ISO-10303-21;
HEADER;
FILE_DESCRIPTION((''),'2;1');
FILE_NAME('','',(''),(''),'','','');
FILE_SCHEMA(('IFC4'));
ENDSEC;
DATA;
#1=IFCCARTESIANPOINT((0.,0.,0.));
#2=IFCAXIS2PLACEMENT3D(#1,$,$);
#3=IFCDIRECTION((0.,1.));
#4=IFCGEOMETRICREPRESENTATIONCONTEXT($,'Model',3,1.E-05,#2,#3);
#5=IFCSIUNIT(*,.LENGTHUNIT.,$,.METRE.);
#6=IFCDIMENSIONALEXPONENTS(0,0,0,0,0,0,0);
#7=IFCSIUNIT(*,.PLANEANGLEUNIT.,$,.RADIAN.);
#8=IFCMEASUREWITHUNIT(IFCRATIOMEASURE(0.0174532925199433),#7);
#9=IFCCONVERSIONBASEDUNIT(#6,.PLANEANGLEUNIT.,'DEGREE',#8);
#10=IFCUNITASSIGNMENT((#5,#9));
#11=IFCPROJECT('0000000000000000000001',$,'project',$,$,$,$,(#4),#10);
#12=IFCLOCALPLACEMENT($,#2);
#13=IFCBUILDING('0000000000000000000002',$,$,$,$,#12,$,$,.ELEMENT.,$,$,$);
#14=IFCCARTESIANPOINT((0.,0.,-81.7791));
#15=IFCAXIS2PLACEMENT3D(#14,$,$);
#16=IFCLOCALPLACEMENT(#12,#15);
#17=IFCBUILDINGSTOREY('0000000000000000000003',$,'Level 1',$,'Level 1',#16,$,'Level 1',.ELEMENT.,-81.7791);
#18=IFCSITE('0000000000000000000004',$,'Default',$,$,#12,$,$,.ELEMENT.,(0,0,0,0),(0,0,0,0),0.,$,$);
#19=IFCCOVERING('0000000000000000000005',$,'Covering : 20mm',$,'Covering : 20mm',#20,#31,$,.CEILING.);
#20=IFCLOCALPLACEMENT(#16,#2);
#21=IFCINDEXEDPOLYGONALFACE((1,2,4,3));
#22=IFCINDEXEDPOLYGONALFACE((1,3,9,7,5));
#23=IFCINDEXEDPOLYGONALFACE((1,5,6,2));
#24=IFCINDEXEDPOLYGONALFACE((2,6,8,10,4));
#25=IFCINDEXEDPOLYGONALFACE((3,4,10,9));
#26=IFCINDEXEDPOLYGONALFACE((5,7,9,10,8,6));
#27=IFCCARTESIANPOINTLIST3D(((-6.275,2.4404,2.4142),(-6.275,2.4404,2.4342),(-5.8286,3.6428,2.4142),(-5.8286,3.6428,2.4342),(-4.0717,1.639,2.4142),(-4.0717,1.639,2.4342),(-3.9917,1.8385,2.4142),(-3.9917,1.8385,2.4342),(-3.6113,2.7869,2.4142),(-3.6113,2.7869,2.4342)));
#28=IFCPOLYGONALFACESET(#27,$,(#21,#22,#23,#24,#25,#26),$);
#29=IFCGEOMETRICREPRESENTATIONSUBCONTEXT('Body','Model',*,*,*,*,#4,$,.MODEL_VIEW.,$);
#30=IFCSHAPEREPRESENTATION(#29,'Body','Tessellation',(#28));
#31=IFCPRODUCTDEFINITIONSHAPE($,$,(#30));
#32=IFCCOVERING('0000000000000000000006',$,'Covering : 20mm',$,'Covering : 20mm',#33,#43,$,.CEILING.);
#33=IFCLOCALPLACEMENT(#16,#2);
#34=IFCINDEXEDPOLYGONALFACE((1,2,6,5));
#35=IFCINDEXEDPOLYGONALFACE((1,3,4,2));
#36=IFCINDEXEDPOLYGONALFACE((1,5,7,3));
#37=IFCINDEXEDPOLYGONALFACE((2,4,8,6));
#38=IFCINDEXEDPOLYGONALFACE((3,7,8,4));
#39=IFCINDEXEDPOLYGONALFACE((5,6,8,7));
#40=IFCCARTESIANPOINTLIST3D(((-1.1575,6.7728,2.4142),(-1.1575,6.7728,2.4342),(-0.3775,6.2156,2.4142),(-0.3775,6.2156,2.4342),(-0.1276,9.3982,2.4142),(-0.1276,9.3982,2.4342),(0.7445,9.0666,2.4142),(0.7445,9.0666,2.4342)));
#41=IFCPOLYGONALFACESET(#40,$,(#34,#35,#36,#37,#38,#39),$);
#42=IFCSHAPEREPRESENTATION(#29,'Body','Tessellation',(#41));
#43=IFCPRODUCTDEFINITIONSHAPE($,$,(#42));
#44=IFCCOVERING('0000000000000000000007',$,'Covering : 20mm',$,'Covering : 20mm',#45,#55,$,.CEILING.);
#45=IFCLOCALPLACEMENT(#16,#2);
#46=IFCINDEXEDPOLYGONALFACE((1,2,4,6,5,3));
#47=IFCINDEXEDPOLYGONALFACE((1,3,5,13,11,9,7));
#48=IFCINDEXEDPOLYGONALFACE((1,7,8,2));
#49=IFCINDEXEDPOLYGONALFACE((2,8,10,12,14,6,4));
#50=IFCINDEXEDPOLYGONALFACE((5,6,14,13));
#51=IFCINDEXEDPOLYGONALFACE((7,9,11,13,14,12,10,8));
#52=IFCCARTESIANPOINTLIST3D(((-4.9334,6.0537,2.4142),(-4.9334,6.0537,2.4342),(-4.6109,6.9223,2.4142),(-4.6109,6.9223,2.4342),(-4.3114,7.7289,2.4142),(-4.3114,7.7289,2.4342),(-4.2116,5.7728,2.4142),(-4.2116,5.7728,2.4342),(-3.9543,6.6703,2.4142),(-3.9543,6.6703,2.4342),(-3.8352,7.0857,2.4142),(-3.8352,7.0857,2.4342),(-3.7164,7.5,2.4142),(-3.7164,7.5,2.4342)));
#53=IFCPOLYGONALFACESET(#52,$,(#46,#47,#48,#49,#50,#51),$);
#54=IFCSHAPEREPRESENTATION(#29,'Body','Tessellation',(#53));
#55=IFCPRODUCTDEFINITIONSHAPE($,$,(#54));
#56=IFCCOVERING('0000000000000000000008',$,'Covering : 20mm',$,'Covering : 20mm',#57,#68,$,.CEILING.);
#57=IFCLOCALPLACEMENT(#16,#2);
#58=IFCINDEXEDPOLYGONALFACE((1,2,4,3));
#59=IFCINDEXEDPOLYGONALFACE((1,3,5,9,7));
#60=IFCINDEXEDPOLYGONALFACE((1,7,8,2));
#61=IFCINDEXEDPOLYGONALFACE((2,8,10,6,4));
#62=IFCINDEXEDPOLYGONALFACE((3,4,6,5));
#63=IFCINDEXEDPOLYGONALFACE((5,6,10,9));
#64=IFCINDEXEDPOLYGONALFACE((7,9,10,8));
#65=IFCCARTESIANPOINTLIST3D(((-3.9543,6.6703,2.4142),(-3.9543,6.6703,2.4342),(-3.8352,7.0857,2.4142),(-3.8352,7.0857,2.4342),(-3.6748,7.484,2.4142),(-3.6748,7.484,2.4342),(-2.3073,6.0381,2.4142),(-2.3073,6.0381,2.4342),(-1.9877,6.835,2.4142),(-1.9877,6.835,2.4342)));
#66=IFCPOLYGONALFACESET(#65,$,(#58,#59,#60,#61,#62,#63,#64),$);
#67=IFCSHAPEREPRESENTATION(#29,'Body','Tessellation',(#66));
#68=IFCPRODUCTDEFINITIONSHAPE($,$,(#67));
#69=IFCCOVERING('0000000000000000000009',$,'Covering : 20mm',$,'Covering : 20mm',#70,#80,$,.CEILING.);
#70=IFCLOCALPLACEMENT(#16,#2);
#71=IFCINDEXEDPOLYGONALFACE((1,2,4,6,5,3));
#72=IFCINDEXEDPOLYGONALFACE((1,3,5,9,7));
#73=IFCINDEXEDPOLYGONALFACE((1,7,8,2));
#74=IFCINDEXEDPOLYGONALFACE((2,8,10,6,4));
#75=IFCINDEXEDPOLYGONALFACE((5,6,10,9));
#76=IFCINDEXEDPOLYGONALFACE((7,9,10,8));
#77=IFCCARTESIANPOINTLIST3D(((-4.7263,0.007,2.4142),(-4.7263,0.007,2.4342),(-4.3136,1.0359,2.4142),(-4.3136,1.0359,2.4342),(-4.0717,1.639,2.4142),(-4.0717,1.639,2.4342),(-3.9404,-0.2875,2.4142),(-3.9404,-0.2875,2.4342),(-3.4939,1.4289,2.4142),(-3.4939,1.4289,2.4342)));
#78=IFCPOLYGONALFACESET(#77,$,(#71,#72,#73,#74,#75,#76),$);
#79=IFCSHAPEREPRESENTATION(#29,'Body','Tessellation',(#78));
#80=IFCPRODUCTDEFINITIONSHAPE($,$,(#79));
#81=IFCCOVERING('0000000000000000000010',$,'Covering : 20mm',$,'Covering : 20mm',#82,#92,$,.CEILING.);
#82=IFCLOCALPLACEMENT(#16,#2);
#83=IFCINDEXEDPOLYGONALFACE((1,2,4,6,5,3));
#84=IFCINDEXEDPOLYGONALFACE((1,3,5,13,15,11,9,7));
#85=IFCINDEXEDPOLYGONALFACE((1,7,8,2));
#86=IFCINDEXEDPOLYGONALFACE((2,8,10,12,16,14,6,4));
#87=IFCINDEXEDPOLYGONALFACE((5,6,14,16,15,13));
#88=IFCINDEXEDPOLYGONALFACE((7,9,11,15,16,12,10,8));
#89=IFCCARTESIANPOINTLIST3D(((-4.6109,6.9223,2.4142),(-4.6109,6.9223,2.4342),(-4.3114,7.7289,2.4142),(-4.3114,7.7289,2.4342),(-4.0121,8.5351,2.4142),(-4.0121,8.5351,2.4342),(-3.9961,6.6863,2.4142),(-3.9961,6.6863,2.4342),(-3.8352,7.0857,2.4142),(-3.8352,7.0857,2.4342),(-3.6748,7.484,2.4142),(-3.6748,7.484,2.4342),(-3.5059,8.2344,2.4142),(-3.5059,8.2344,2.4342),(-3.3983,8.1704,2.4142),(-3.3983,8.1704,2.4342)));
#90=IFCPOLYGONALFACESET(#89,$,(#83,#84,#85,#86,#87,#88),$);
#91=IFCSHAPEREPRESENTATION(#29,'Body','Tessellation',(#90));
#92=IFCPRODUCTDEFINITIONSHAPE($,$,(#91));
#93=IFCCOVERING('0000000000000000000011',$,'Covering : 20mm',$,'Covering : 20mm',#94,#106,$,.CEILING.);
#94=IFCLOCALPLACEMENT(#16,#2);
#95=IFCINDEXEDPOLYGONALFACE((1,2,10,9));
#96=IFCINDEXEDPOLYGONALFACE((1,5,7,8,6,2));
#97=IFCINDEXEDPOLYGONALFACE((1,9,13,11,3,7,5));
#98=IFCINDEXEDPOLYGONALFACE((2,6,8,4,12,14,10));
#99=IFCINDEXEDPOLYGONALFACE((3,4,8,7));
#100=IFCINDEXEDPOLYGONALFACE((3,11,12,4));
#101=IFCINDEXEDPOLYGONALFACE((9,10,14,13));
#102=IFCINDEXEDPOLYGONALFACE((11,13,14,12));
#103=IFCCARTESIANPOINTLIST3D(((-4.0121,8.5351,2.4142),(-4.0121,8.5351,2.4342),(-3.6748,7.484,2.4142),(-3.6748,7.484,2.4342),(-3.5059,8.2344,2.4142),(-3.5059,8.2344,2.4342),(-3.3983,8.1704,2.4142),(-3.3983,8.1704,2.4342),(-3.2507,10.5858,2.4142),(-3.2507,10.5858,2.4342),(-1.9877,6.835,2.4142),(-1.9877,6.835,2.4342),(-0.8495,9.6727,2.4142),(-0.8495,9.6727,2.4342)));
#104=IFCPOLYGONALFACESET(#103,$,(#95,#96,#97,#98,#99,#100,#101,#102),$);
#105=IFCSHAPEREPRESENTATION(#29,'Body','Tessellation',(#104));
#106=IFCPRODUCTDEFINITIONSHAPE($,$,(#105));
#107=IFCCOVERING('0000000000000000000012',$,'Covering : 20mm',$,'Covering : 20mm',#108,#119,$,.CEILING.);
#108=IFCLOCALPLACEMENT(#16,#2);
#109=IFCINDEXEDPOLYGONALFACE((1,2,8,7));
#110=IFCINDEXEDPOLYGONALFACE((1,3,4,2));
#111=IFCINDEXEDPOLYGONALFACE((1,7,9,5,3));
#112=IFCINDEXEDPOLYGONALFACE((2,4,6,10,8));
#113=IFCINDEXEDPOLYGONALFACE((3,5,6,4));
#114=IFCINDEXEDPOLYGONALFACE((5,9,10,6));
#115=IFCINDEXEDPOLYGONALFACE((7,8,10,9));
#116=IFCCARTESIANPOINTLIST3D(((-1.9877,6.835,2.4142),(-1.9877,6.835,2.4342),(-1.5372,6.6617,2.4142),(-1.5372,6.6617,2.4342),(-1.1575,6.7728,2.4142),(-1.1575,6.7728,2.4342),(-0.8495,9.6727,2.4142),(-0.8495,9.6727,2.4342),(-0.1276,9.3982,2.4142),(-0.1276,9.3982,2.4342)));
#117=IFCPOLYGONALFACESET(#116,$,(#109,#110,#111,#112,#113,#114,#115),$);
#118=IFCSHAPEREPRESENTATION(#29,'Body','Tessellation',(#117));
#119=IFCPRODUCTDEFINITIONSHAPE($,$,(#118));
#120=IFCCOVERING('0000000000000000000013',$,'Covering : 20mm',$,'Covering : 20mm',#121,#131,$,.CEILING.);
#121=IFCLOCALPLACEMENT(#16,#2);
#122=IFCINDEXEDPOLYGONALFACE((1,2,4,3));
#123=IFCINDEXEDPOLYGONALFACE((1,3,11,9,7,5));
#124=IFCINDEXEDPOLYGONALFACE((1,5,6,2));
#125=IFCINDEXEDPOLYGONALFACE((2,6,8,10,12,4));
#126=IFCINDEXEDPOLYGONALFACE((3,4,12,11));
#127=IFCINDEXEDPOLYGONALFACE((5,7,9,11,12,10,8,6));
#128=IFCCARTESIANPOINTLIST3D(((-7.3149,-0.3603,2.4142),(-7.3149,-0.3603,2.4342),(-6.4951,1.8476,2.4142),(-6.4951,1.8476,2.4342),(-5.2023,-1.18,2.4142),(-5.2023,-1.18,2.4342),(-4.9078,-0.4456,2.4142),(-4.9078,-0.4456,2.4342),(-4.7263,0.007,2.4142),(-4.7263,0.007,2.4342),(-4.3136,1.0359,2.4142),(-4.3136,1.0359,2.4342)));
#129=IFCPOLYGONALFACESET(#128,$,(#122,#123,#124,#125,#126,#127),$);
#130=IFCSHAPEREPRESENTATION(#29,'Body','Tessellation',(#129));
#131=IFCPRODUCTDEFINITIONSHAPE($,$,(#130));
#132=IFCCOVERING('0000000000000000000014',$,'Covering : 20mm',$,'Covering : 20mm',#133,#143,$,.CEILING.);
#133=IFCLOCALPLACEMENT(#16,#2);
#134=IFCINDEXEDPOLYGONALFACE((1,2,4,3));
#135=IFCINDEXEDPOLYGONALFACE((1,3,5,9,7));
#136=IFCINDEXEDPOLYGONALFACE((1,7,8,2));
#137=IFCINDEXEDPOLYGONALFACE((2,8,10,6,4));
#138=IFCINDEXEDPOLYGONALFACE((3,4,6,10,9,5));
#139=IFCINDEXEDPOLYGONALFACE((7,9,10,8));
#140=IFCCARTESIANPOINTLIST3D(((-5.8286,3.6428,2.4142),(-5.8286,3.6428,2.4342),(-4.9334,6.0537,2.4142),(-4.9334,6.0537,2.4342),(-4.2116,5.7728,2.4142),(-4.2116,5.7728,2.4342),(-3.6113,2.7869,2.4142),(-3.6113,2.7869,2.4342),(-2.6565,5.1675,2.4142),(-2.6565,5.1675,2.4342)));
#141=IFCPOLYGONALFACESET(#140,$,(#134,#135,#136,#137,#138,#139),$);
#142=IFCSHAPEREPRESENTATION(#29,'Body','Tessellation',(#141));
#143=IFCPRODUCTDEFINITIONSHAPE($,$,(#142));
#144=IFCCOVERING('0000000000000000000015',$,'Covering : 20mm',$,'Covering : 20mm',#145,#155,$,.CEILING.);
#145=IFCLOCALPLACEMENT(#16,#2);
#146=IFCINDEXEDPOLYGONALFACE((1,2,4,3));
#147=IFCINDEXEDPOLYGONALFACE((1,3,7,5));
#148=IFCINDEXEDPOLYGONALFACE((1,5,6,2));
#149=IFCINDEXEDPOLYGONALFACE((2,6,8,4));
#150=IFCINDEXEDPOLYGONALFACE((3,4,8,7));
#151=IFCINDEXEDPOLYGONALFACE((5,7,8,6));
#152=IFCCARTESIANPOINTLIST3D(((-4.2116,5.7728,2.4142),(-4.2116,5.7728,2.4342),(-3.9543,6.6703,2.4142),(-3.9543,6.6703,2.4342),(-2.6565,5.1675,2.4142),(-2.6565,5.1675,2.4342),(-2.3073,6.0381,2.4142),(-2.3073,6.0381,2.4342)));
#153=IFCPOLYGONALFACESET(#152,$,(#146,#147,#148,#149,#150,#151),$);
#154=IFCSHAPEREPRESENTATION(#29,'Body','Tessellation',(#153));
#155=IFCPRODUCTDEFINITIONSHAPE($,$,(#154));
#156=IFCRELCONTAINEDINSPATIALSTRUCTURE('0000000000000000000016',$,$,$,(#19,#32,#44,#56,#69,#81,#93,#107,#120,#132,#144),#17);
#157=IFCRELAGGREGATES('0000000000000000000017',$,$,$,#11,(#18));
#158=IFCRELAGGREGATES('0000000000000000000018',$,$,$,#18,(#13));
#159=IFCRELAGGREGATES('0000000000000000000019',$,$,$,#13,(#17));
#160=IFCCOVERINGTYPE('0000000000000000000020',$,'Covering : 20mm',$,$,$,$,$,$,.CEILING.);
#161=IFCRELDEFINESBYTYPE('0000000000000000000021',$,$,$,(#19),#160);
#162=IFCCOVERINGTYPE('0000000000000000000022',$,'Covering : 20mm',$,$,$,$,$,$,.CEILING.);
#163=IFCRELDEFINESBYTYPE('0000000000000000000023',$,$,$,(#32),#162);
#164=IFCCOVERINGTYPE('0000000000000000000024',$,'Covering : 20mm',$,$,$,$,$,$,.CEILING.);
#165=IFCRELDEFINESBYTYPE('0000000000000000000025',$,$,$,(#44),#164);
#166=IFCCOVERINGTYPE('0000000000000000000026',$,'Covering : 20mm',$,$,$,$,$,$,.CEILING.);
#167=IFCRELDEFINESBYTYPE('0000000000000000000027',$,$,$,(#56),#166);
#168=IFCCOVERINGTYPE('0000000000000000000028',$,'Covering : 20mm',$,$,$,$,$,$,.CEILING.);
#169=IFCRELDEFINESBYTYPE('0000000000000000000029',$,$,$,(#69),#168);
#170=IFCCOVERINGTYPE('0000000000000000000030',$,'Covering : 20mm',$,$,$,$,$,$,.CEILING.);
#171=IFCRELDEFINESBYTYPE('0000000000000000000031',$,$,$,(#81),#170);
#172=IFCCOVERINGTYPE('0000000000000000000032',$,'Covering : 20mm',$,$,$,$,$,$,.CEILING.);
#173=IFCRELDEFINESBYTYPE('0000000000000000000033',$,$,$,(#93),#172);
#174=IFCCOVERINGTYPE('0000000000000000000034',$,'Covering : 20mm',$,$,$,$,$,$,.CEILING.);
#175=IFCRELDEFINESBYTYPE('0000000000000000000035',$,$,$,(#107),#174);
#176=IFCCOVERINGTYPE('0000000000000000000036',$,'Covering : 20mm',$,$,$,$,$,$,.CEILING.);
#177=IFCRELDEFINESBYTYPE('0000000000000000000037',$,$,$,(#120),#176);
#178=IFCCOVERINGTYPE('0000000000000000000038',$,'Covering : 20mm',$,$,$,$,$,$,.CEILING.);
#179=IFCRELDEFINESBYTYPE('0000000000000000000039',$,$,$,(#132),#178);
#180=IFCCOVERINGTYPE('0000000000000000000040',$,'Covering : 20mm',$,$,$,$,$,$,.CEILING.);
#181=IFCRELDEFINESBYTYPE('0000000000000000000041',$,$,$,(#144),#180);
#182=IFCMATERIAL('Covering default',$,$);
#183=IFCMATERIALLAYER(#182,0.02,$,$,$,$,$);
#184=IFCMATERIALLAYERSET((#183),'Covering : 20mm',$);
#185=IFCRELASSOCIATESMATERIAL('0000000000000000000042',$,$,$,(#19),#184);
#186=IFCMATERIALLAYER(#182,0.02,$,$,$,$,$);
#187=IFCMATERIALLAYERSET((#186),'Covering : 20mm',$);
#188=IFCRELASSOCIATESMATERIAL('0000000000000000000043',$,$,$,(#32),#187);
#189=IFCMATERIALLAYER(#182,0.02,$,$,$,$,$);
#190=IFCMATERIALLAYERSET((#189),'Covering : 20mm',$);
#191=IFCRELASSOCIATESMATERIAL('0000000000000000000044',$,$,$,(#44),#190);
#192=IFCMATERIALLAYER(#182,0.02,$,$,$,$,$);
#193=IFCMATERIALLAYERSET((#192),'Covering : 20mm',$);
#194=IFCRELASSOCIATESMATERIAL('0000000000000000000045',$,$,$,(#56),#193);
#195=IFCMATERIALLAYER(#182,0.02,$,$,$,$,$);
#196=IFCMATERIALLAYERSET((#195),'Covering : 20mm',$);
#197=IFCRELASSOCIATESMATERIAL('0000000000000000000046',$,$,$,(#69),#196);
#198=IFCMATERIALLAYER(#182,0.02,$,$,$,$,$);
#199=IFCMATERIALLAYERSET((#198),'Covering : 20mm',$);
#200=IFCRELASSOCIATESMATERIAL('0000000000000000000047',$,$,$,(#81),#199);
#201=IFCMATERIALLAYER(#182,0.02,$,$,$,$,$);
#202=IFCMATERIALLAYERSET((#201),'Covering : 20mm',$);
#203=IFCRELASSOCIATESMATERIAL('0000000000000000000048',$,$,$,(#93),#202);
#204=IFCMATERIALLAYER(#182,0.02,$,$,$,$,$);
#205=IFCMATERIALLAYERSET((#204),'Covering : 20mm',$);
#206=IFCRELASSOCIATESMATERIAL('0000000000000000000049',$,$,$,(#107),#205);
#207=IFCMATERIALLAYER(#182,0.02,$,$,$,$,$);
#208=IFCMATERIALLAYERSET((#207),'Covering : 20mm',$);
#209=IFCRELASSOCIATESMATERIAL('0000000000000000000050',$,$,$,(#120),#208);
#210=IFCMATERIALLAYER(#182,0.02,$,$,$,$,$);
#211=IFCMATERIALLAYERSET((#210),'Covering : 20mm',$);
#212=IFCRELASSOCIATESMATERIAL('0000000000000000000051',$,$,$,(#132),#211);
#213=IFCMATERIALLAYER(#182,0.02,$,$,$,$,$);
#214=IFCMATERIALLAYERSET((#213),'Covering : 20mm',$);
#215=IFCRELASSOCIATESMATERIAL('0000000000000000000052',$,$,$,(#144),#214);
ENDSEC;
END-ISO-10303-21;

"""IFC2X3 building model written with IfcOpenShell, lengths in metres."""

from ifc_helpers import new_model, entity, si_unit, converted_unit, direction, frame, origin, origin_with_axes, place, context, subcontext, project, spatial, polyline, outline, extrude, material, layer, layer_set, layer_usage, type_object, element, save


model = new_model("IFC2X3")

# Units and contexts
model_context = context("Model", 3, precision=1e-05, world=origin(), true_north=direction((0.0, 1.0)))
body_context = subcontext(model_context, "Body", "Model", "MODEL_VIEW")
ifc_project = project(units=[si_unit("LENGTHUNIT", "METRE"), converted_unit("PLANEANGLEUNIT", "DEGREE", entity("IfcRatioMeasure", 0.0174532925199433), si_unit("PLANEANGLEUNIT", "RADIAN"), dimensions=[0, 0, 0, 0, 0, 0, 0])], contexts=[model_context])

# Site, building, storey
placement = place(None, origin())
site = spatial("IfcSite", under=ifc_project, at=placement, Name="Default", CompositionType="ELEMENT", RefLatitude=(0, 0, 0, 0), RefLongitude=(0, 0, 0, 0), RefElevation=0.0)
building = spatial("IfcBuilding", under=site, at=placement, CompositionType="ELEMENT")
storey_placement = place(placement, frame((0.0, 0.0, -81.7791)))
storey = spatial("IfcBuildingStorey", under=building, at=storey_placement, Name="Level 1", ObjectType="Level 1", LongName="Level 1", CompositionType="ELEMENT", Elevation=-81.7791)

# Coverings
ifc_material_1 = material(Name="Covering default")
ifc_layer_1 = layer(ifc_material_1, 0.02)
ifc_layer_set_1 = layer_set([ifc_layer_1], Name="Covering : 20mm")
ifc_layer_usage_1 = layer_usage(ifc_layer_set_1, "AXIS3", "POSITIVE", 0.0)
covering_type_1 = type_object("IfcCoveringType", Name="Covering : 20mm", PredefinedType="CEILING")
covering_1_placement = place(placement, frame((0.0, 0.0, -79.3649)))
element("IfcCovering", 1, at=covering_1_placement, inside=storey, type_object=covering_type_1, material=ifc_layer_usage_1, Name="Covering : 20mm", ObjectType="Covering : 20mm", PredefinedType="CEILING", context=body_context, shape_type="SweptSolid", body=[
    extrude(outline(polyline([(-6.275, 2.4404), (-5.8286, 3.6428), (-3.6113, 2.7869), (-3.9917, 1.8385), (-4.0717, 1.639), (-6.275, 2.4404)])), origin_with_axes(), (0.0, 0.0, 1.0), 0.02),
])
ifc_layer_2 = layer(ifc_material_1, 0.02)
ifc_layer_set_2 = layer_set([ifc_layer_2], Name="Covering : 20mm")
ifc_layer_usage_2 = layer_usage(ifc_layer_set_2, "AXIS3", "POSITIVE", 0.0)
covering_type_2 = type_object("IfcCoveringType", Name="Covering : 20mm", PredefinedType="CEILING")
covering_2_placement = place(placement, frame((0.0, 0.0, -79.3649)))
element("IfcCovering", 2, at=covering_2_placement, inside=storey, type_object=covering_type_2, material=ifc_layer_usage_2, Name="Covering : 20mm", ObjectType="Covering : 20mm", PredefinedType="CEILING", context=body_context, shape_type="SweptSolid", body=[
    extrude(outline(polyline([(-1.1575, 6.7728), (-0.1276, 9.3982), (0.7445, 9.0666), (-0.3775, 6.2156), (-1.1575, 6.7728)])), origin_with_axes(), (0.0, 0.0, 1.0), 0.02),
])
ifc_layer_3 = layer(ifc_material_1, 0.02)
ifc_layer_set_3 = layer_set([ifc_layer_3], Name="Covering : 20mm")
ifc_layer_usage_3 = layer_usage(ifc_layer_set_3, "AXIS3", "POSITIVE", 0.0)
covering_type_3 = type_object("IfcCoveringType", Name="Covering : 20mm", PredefinedType="CEILING")
covering_3_placement = place(placement, frame((0.0, 0.0, -79.3649)))
element("IfcCovering", 3, at=covering_3_placement, inside=storey, type_object=covering_type_3, material=ifc_layer_usage_3, Name="Covering : 20mm", ObjectType="Covering : 20mm", PredefinedType="CEILING", context=body_context, shape_type="SweptSolid", body=[
    extrude(outline(polyline([(-3.8352, 7.0857), (-3.7164, 7.5), (-4.3114, 7.7289), (-4.6109, 6.9223), (-4.9334, 6.0537), (-4.2116, 5.7728), (-3.9543, 6.6703), (-3.8352, 7.0857)])), origin_with_axes(), (0.0, 0.0, 1.0), 0.02),
])
ifc_layer_4 = layer(ifc_material_1, 0.02)
ifc_layer_set_4 = layer_set([ifc_layer_4], Name="Covering : 20mm")
ifc_layer_usage_4 = layer_usage(ifc_layer_set_4, "AXIS3", "POSITIVE", 0.0)
covering_type_4 = type_object("IfcCoveringType", Name="Covering : 20mm", PredefinedType="CEILING")
covering_4_placement = place(placement, frame((0.0, 0.0, -79.3649)))
element("IfcCovering", 4, at=covering_4_placement, inside=storey, type_object=covering_type_4, material=ifc_layer_usage_4, Name="Covering : 20mm", ObjectType="Covering : 20mm", PredefinedType="CEILING", context=body_context, shape_type="SweptSolid", body=[
    extrude(outline(polyline([(-3.8352, 7.0857), (-3.9543, 6.6703), (-2.3073, 6.0381), (-1.9877, 6.835), (-3.6748, 7.484), (-3.8352, 7.0857)])), origin_with_axes(), (0.0, 0.0, 1.0), 0.02),
])
ifc_layer_5 = layer(ifc_material_1, 0.02)
ifc_layer_set_5 = layer_set([ifc_layer_5], Name="Covering : 20mm")
ifc_layer_usage_5 = layer_usage(ifc_layer_set_5, "AXIS3", "POSITIVE", 0.0)
covering_type_5 = type_object("IfcCoveringType", Name="Covering : 20mm", PredefinedType="CEILING")
covering_5_placement = place(placement, frame((0.0, 0.0, -79.3649)))
element("IfcCovering", 5, at=covering_5_placement, inside=storey, type_object=covering_type_5, material=ifc_layer_usage_5, Name="Covering : 20mm", ObjectType="Covering : 20mm", PredefinedType="CEILING", context=body_context, shape_type="SweptSolid", body=[
    extrude(outline(polyline([(-3.4939, 1.4289), (-4.0717, 1.639), (-4.3136, 1.0359), (-4.7263, 0.007), (-3.9404, -0.2875), (-3.4939, 1.4289)])), origin_with_axes(), (0.0, 0.0, 1.0), 0.02),
])
ifc_layer_6 = layer(ifc_material_1, 0.02)
ifc_layer_set_6 = layer_set([ifc_layer_6], Name="Covering : 20mm")
ifc_layer_usage_6 = layer_usage(ifc_layer_set_6, "AXIS3", "POSITIVE", 0.0)
covering_type_6 = type_object("IfcCoveringType", Name="Covering : 20mm", PredefinedType="CEILING")
covering_6_placement = place(placement, frame((0.0, 0.0, -79.3649)))
element("IfcCovering", 6, at=covering_6_placement, inside=storey, type_object=covering_type_6, material=ifc_layer_usage_6, Name="Covering : 20mm", ObjectType="Covering : 20mm", PredefinedType="CEILING", context=body_context, shape_type="SweptSolid", body=[
    extrude(outline(polyline([(-3.5059, 8.2344), (-4.0121, 8.5351), (-4.3114, 7.7289), (-4.6109, 6.9223), (-3.9961, 6.6863), (-3.8352, 7.0857), (-3.6748, 7.484), (-3.3983, 8.1704), (-3.5059, 8.2344)])), origin_with_axes(), (0.0, 0.0, 1.0), 0.02),
])
ifc_layer_7 = layer(ifc_material_1, 0.02)
ifc_layer_set_7 = layer_set([ifc_layer_7], Name="Covering : 20mm")
ifc_layer_usage_7 = layer_usage(ifc_layer_set_7, "AXIS3", "POSITIVE", 0.0)
covering_type_7 = type_object("IfcCoveringType", Name="Covering : 20mm", PredefinedType="CEILING")
covering_7_placement = place(placement, frame((0.0, 0.0, -79.3649)))
element("IfcCovering", 7, at=covering_7_placement, inside=storey, type_object=covering_type_7, material=ifc_layer_usage_7, Name="Covering : 20mm", ObjectType="Covering : 20mm", PredefinedType="CEILING", context=body_context, shape_type="SweptSolid", body=[
    extrude(outline(polyline([(-3.5059, 8.2344), (-4.0121, 8.5351), (-3.2507, 10.5858), (-0.8495, 9.6727), (-1.9877, 6.835), (-3.6748, 7.484), (-3.3983, 8.1704), (-3.5059, 8.2344)])), origin_with_axes(), (0.0, 0.0, 1.0), 0.02),
])
ifc_layer_8 = layer(ifc_material_1, 0.02)
ifc_layer_set_8 = layer_set([ifc_layer_8], Name="Covering : 20mm")
ifc_layer_usage_8 = layer_usage(ifc_layer_set_8, "AXIS3", "POSITIVE", 0.0)
covering_type_8 = type_object("IfcCoveringType", Name="Covering : 20mm", PredefinedType="CEILING")
covering_8_placement = place(placement, frame((0.0, 0.0, -79.3649)))
element("IfcCovering", 8, at=covering_8_placement, inside=storey, type_object=covering_type_8, material=ifc_layer_usage_8, Name="Covering : 20mm", ObjectType="Covering : 20mm", PredefinedType="CEILING", context=body_context, shape_type="SweptSolid", body=[
    extrude(outline(polyline([(-1.1575, 6.7728), (-0.1276, 9.3982), (-0.8495, 9.6727), (-1.9877, 6.835), (-1.5372, 6.6617), (-1.1575, 6.7728)])), origin_with_axes(), (0.0, 0.0, 1.0), 0.02),
])
ifc_layer_9 = layer(ifc_material_1, 0.02)
ifc_layer_set_9 = layer_set([ifc_layer_9], Name="Covering : 20mm")
ifc_layer_usage_9 = layer_usage(ifc_layer_set_9, "AXIS3", "POSITIVE", 0.0)
covering_type_9 = type_object("IfcCoveringType", Name="Covering : 20mm", PredefinedType="CEILING")
covering_9_placement = place(placement, frame((0.0, 0.0, -79.3649)))
element("IfcCovering", 9, at=covering_9_placement, inside=storey, type_object=covering_type_9, material=ifc_layer_usage_9, Name="Covering : 20mm", ObjectType="Covering : 20mm", PredefinedType="CEILING", context=body_context, shape_type="SweptSolid", body=[
    extrude(outline(polyline([(-4.3136, 1.0359), (-6.4951, 1.8476), (-7.3149, -0.3603), (-5.2023, -1.18), (-4.9078, -0.4456), (-4.7263, 0.007), (-4.3136, 1.0359)])), origin_with_axes(), (0.0, 0.0, 1.0), 0.02),
])
ifc_layer_10 = layer(ifc_material_1, 0.02)
ifc_layer_set_10 = layer_set([ifc_layer_10], Name="Covering : 20mm")
ifc_layer_usage_10 = layer_usage(ifc_layer_set_10, "AXIS3", "POSITIVE", 0.0)
covering_type_10 = type_object("IfcCoveringType", Name="Covering : 20mm", PredefinedType="CEILING")
covering_10_placement = place(placement, frame((0.0, 0.0, -79.3649)))
element("IfcCovering", 10, at=covering_10_placement, inside=storey, type_object=covering_type_10, material=ifc_layer_usage_10, Name="Covering : 20mm", ObjectType="Covering : 20mm", PredefinedType="CEILING", context=body_context, shape_type="SweptSolid", body=[
    extrude(outline(polyline([(-4.9334, 6.0537), (-5.8286, 3.6428), (-3.6113, 2.7869), (-2.6565, 5.1675), (-4.2116, 5.7728), (-4.9334, 6.0537)])), origin_with_axes(), (0.0, 0.0, 1.0), 0.02),
])
ifc_layer_11 = layer(ifc_material_1, 0.02)
ifc_layer_set_11 = layer_set([ifc_layer_11], Name="Covering : 20mm")
ifc_layer_usage_11 = layer_usage(ifc_layer_set_11, "AXIS3", "POSITIVE", 0.0)
covering_type_11 = type_object("IfcCoveringType", Name="Covering : 20mm", PredefinedType="CEILING")
covering_11_placement = place(placement, frame((0.0, 0.0, -79.3649)))
element("IfcCovering", 11, at=covering_11_placement, inside=storey, type_object=covering_type_11, material=ifc_layer_usage_11, Name="Covering : 20mm", ObjectType="Covering : 20mm", PredefinedType="CEILING", context=body_context, shape_type="SweptSolid", body=[
    extrude(outline(polyline([(-4.2116, 5.7728), (-3.9543, 6.6703), (-2.3073, 6.0381), (-2.6565, 5.1675), (-4.2116, 5.7728)])), origin_with_axes(), (0.0, 0.0, 1.0), 0.02),
])

save(model, "model.ifc")
